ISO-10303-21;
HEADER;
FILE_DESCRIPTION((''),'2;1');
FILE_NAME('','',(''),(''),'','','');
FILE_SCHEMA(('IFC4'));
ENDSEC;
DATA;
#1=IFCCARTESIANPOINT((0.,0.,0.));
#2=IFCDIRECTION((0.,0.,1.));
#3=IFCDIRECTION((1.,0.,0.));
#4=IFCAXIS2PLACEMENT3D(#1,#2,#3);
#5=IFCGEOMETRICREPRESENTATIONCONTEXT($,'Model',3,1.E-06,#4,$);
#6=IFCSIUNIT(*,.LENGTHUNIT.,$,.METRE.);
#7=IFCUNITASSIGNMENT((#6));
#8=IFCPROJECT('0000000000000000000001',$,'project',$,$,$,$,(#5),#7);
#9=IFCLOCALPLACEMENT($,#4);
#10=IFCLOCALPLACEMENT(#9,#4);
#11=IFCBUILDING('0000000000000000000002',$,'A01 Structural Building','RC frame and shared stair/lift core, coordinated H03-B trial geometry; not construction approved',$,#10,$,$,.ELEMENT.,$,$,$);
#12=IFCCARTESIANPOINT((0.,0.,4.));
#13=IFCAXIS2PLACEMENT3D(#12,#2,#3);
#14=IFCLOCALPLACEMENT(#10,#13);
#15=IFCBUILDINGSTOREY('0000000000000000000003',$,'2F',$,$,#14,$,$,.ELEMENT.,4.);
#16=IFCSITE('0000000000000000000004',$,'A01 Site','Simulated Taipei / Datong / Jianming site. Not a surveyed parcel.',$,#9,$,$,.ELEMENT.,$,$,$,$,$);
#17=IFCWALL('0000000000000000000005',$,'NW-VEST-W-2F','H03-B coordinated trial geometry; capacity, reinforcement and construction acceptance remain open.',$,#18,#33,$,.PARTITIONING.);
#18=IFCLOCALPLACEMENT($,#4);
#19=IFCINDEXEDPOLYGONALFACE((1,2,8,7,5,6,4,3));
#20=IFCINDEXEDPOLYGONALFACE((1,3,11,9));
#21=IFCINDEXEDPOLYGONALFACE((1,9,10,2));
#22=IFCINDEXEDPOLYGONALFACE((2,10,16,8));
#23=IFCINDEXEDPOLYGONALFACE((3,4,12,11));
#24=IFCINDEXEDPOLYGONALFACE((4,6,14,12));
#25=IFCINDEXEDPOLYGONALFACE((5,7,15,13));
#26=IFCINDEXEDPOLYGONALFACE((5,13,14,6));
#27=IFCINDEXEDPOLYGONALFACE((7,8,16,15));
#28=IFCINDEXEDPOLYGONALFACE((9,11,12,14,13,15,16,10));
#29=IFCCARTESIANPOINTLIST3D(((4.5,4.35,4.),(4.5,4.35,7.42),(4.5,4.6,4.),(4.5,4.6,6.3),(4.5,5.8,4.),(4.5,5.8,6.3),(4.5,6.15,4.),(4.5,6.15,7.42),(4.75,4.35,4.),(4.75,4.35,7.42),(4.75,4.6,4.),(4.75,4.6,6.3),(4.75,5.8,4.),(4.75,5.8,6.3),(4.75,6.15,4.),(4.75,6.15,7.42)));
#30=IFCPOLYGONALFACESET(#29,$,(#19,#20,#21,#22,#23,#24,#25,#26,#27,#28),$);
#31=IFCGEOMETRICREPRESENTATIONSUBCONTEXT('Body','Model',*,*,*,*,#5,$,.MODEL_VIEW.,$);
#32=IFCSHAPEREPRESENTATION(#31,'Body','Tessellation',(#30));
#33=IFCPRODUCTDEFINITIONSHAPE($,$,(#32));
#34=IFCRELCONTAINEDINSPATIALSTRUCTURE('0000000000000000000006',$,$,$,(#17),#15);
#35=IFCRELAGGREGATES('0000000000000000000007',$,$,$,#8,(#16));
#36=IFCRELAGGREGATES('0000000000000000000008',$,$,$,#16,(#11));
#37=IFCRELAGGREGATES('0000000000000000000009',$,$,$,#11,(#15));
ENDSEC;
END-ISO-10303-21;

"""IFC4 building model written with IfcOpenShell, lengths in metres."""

from ifc_helpers import new_model, si_unit, frame, origin_with_axes, place, context, subcontext, project, spatial, polyline, outline, extrude, element, save


model = new_model("IFC4")

# Units and contexts
model_context = context("Model", 3, precision=1e-06, world=origin_with_axes())
body_context = subcontext(model_context, "Body", "Model", "MODEL_VIEW")
ifc_project = project(units=[si_unit("LENGTHUNIT", "METRE")], contexts=[model_context])

# Site, building, storey
site_placement = place(None, origin_with_axes())
site = spatial("IfcSite", under=ifc_project, at=site_placement, Name="A01 Site", Description="Simulated Taipei / Datong / Jianming site. Not a surveyed parcel.", CompositionType="ELEMENT")
building_placement = place(site_placement, origin_with_axes())
building = spatial("IfcBuilding", under=site, at=building_placement, Name="A01 Structural Building", Description="RC frame and shared stair/lift core, coordinated H03-B trial geometry; not construction approved", CompositionType="ELEMENT")
storey_placement = place(building_placement, frame((0.0, 0.0, 4.0), z_axis=(0.0, 0.0, 1.0), x_axis=(1.0, 0.0, 0.0)))
storey = spatial("IfcBuildingStorey", under=building, at=storey_placement, Name="2F", CompositionType="ELEMENT", Elevation=4.0)

# Shared definitions
placement = place(None, origin_with_axes())

# Wall, opening
wall_1 = element("IfcWall", 1, at=placement, inside=storey, Name="NW-VEST-W-2F", Description="H03-B coordinated trial geometry; capacity, reinforcement and construction acceptance remain open.", PredefinedType="PARTITIONING", context=body_context, shape_type="SweptSolid", body=[
    extrude(outline(polyline([(4.75, 4.35), (4.75, 6.15), (4.5, 6.15), (4.5, 4.35), (4.75, 4.35)])), frame((0.0, 0.0, 4.0), z_axis=(0.0, 0.0, 1.0), x_axis=(1.0, 0.0, 0.0)), (0.0, 0.0, 1.0), 3.42),
])
element("IfcOpeningElement", 2, at=placement, cuts=wall_1, PredefinedType="OPENING", context=body_context, shape_type="SweptSolid", body=[
    extrude(outline(polyline([(4.8, 4.6), (4.8, 5.8), (4.45, 5.8), (4.45, 4.6), (4.8, 4.6)])), frame((0.0, 0.0, 4.0), z_axis=(0.0, 0.0, 1.0), x_axis=(1.0, 0.0, 0.0)), (0.0, 0.0, 1.0), 2.3),
])

save(model, "model.ifc")
